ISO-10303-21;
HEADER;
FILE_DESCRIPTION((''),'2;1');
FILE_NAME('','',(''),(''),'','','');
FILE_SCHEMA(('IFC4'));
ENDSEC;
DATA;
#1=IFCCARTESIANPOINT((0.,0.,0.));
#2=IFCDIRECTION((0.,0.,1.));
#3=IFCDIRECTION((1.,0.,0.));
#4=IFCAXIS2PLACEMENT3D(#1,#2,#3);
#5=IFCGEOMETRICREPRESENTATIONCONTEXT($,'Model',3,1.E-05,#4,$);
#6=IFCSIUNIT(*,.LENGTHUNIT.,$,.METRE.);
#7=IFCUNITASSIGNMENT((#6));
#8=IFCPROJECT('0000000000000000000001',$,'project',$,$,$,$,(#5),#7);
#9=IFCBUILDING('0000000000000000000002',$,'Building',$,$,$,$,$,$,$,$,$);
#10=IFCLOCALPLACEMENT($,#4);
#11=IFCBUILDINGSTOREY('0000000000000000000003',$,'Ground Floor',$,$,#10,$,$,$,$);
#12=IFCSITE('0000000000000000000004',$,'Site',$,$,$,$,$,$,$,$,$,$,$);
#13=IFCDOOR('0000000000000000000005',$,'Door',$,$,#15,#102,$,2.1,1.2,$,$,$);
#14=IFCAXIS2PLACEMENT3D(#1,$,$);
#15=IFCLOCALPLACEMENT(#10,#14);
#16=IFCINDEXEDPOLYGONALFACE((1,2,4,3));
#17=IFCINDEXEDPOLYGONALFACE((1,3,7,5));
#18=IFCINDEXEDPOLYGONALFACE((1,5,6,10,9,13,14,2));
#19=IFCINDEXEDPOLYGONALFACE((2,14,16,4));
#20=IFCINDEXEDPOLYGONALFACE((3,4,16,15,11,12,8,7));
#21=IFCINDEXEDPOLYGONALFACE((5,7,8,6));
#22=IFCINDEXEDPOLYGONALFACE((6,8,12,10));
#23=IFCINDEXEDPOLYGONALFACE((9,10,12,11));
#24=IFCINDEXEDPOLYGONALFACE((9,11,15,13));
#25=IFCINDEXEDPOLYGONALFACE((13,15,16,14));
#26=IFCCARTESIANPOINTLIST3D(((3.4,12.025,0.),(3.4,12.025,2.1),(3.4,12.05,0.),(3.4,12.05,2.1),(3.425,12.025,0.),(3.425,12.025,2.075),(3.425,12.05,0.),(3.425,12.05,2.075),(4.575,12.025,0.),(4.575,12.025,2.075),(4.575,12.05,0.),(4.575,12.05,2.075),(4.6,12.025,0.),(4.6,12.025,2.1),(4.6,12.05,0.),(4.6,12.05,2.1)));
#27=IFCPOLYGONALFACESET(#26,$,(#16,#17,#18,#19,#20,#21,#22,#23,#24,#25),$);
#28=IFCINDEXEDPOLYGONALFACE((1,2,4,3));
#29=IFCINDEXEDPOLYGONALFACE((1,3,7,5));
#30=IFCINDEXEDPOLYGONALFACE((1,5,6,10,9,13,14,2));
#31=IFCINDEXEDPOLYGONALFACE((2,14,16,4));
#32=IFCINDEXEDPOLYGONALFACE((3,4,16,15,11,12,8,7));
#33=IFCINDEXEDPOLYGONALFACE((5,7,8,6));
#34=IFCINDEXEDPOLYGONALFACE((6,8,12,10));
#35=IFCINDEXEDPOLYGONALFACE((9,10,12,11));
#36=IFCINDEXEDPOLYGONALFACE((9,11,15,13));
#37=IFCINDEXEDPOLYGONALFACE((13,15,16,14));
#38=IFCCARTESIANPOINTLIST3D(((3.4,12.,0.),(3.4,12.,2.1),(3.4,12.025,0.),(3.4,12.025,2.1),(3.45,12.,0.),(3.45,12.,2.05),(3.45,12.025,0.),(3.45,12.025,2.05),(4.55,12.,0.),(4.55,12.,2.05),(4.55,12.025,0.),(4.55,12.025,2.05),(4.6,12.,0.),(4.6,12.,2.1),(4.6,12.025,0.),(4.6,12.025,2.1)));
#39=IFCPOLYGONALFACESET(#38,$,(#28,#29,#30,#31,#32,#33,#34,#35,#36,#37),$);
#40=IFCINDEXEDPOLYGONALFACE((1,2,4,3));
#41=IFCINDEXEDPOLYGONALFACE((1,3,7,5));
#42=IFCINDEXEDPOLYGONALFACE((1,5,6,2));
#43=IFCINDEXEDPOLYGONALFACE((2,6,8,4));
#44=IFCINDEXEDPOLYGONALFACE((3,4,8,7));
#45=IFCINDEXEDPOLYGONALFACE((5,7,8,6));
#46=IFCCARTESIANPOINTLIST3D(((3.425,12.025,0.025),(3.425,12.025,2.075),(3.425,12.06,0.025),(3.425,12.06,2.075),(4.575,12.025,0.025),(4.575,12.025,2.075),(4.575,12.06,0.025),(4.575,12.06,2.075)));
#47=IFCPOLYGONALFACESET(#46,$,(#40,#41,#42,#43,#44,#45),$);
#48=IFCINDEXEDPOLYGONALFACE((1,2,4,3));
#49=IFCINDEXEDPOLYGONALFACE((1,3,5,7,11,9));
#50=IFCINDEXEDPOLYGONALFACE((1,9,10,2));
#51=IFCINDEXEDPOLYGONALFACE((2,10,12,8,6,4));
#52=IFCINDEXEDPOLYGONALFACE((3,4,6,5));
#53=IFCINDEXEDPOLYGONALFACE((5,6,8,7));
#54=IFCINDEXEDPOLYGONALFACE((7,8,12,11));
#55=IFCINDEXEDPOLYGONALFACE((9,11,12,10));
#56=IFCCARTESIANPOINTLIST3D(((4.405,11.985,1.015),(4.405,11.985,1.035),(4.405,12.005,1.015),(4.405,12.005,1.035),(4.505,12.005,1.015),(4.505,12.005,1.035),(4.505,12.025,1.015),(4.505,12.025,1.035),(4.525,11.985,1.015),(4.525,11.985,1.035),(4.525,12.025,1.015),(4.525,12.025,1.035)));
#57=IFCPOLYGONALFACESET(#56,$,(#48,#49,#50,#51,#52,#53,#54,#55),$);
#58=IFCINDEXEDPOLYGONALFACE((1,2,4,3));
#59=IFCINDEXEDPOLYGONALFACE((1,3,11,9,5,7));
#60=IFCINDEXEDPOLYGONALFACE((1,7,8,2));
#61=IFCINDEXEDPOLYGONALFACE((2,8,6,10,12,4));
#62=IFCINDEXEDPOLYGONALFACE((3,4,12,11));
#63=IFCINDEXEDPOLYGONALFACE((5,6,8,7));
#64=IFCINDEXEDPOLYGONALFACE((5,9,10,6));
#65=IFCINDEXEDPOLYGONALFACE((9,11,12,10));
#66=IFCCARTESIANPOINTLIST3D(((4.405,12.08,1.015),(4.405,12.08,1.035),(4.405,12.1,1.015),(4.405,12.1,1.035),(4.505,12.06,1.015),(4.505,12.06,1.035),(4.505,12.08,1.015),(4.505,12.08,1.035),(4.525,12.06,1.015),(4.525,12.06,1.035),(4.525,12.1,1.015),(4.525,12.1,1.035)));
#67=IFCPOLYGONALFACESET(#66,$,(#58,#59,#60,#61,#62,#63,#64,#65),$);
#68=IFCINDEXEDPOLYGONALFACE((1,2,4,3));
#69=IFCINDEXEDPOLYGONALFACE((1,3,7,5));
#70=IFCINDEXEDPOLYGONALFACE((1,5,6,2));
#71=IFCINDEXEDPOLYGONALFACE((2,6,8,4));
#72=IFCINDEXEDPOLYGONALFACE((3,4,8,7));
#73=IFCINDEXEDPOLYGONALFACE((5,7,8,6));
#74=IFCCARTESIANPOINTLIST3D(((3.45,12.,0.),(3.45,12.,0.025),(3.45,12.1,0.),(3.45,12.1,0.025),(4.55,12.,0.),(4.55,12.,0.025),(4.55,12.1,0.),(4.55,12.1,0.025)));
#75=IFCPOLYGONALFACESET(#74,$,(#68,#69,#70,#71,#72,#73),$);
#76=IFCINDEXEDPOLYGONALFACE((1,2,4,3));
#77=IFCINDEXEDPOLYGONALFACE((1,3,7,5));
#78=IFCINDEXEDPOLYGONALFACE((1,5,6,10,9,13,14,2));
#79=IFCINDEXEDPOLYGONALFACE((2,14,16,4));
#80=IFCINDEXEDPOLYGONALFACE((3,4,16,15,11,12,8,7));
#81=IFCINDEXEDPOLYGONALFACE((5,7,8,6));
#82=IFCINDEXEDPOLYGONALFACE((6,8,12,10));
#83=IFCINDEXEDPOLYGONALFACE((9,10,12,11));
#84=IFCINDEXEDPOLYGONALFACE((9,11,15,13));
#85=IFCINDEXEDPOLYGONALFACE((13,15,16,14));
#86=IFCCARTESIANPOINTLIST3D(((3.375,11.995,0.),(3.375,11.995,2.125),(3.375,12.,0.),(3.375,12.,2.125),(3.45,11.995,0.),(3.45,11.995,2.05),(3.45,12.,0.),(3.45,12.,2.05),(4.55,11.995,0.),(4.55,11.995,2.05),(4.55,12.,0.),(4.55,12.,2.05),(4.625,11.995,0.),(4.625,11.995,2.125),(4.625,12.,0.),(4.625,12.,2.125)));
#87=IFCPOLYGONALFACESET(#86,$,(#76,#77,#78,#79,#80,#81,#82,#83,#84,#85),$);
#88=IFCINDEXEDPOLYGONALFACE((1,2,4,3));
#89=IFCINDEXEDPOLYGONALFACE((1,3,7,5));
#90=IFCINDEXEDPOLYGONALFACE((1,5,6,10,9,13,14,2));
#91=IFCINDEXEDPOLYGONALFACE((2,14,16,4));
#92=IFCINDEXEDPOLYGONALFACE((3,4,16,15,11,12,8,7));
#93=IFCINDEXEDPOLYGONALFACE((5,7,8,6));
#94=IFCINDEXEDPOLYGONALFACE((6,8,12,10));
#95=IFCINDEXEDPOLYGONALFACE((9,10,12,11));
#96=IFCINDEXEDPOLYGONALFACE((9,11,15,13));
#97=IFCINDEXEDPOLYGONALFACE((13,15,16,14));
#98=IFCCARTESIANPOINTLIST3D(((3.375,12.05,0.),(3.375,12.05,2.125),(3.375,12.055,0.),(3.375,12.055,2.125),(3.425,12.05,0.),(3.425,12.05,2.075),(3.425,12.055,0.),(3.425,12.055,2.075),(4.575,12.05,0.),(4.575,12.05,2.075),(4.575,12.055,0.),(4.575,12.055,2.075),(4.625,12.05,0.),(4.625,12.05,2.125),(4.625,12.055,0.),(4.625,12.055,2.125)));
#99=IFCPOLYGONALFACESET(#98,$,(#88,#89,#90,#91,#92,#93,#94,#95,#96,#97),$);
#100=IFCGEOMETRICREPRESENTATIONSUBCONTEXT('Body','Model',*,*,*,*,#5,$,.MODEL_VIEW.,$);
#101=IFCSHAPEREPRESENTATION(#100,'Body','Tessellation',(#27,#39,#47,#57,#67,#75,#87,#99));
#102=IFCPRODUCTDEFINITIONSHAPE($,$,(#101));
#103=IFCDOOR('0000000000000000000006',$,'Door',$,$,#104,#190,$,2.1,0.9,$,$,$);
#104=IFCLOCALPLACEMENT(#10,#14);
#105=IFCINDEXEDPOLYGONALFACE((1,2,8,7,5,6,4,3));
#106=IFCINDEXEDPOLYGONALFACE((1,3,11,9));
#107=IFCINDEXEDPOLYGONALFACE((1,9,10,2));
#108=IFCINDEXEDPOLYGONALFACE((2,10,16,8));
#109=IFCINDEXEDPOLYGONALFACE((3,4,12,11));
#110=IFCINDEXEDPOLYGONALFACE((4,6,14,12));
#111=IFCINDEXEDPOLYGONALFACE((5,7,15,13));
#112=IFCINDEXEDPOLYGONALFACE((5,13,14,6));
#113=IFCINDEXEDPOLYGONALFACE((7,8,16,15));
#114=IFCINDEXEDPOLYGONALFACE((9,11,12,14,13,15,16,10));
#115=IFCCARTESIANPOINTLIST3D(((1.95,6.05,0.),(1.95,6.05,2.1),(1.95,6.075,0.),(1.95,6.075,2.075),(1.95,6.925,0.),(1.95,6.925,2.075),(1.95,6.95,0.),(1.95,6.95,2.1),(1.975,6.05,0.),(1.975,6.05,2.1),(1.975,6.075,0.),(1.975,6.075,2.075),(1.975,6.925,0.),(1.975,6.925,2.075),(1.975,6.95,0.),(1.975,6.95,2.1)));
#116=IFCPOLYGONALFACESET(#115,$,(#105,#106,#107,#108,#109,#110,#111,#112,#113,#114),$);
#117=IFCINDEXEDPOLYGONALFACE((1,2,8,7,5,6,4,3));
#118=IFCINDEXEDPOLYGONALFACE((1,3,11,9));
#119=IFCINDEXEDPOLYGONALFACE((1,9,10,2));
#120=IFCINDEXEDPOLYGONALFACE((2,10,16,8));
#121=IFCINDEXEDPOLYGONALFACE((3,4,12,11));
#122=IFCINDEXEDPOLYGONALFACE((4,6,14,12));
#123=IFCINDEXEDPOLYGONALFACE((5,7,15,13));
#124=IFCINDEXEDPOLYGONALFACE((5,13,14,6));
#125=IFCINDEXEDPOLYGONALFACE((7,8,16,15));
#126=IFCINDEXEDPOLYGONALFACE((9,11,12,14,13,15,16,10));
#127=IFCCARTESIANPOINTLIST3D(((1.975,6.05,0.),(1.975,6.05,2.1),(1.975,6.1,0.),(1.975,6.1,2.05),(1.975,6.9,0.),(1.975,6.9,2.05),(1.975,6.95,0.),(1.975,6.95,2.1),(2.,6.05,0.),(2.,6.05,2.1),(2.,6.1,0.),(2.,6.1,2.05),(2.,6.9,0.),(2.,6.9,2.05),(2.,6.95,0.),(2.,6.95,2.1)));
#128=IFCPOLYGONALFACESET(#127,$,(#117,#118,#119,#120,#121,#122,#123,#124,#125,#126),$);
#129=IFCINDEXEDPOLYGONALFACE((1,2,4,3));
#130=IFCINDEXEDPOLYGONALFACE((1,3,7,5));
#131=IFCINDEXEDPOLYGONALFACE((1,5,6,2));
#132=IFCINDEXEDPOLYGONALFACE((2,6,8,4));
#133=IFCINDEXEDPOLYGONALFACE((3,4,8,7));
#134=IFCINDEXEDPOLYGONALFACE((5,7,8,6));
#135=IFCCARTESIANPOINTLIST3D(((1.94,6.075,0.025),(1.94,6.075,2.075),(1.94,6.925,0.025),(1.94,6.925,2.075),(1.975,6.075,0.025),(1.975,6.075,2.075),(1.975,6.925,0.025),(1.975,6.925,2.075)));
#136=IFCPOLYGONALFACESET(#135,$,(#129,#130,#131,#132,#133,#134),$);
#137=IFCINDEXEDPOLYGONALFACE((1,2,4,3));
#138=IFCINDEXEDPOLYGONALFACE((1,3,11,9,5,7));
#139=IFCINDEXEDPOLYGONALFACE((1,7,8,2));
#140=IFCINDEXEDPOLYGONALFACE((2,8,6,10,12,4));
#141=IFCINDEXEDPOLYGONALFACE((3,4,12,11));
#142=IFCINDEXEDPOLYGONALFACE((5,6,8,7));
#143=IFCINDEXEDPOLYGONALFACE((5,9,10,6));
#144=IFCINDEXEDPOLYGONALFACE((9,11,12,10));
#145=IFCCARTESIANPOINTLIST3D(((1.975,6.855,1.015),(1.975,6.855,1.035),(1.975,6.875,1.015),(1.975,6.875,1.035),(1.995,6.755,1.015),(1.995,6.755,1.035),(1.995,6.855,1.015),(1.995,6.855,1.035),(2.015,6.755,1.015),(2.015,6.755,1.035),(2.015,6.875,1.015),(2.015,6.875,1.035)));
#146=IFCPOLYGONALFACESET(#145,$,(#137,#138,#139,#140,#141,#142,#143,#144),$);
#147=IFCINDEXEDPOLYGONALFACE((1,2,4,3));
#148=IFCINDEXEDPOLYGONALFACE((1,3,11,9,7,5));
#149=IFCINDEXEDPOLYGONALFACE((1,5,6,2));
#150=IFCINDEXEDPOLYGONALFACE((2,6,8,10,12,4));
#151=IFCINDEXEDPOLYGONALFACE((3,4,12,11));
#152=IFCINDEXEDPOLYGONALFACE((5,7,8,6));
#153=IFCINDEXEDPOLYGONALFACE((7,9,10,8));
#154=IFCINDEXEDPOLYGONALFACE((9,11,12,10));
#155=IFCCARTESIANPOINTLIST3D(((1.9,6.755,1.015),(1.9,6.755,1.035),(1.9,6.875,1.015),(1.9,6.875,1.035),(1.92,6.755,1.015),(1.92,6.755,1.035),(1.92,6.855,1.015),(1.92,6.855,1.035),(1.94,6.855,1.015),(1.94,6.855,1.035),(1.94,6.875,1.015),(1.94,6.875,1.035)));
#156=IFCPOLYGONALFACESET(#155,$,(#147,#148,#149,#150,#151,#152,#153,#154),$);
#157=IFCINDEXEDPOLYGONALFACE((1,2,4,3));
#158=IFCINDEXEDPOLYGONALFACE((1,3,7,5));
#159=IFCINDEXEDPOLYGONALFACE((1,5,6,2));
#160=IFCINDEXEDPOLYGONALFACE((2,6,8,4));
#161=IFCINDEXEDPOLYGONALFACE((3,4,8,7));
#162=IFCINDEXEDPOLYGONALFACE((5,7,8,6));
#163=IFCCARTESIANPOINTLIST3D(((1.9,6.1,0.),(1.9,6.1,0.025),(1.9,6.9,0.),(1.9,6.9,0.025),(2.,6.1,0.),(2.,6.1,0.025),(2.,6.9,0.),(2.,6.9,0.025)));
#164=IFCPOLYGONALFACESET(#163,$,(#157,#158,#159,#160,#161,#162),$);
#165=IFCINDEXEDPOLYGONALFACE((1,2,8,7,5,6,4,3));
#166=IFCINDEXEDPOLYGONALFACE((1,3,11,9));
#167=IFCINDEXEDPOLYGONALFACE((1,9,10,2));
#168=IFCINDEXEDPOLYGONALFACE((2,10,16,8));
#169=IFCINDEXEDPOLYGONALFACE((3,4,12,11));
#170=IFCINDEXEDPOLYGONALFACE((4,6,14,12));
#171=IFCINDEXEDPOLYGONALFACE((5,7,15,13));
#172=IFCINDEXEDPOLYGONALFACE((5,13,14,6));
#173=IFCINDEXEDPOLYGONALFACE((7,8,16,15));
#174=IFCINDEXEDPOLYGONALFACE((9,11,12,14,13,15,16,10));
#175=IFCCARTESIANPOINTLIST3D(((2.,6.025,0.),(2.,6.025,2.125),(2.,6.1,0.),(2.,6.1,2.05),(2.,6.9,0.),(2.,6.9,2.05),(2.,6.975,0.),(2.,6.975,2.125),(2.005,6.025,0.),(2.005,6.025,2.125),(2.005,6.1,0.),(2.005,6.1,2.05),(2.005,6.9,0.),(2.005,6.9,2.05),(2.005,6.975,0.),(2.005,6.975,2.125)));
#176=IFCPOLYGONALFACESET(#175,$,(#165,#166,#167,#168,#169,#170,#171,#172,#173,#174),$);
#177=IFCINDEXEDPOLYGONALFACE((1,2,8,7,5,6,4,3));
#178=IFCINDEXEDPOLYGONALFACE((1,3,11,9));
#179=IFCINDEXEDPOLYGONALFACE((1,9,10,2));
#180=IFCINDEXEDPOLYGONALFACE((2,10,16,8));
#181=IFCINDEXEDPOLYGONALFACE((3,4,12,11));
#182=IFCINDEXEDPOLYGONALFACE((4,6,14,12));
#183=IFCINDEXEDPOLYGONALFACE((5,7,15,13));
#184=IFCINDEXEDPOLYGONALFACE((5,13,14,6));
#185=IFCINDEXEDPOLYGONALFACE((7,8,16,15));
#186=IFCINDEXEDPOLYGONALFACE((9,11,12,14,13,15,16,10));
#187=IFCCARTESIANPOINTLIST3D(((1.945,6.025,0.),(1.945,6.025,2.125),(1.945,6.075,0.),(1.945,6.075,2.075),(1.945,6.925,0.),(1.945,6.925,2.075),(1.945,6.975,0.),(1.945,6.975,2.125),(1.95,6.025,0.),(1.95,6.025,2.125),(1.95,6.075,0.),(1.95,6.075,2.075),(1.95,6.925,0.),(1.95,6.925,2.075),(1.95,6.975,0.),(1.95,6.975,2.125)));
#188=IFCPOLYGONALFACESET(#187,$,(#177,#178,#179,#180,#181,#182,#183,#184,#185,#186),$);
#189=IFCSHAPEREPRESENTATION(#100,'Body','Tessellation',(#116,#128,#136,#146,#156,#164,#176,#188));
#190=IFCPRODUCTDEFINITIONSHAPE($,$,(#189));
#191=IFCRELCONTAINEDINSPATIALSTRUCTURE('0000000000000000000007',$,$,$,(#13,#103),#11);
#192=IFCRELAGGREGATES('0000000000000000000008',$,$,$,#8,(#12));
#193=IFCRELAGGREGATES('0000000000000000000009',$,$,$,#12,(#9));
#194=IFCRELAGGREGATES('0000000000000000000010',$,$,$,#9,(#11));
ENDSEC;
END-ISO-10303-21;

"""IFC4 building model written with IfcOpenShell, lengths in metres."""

from ifc_helpers import new_model, si_unit, frame, origin_with_axes, place, context, subcontext, project, spatial, line, indexed_curve, outline, extrude, element, save


model = new_model("IFC4")

# Units and contexts
model_context = context("Model", 3, precision=1e-05, world=origin_with_axes())
body_context = subcontext(model_context, "Body", "Model", "MODEL_VIEW")
ifc_project = project(units=[si_unit("LENGTHUNIT", "METRE")], contexts=[model_context])

# Site, building, storey
site = spatial("IfcSite", under=ifc_project, Name="Site")
building = spatial("IfcBuilding", under=site, Name="Building")
storey_placement = place(None, origin_with_axes())
storey = spatial("IfcBuildingStorey", under=building, at=storey_placement, Name="Ground Floor")

# Doors
door_1_placement = place(storey_placement, frame((3.4, 12.0, 0.0), z_axis=(0.0, 0.0, 1.0), x_axis=(1.0, 0.0, 0.0)))
element("IfcDoor", 1, at=door_1_placement, inside=storey, Name="Door", OverallHeight=2.1, OverallWidth=1.2, context=body_context, shape_type="SweptSolid", body=[
    extrude(outline(indexed_curve([(0.0, 0.0), (0.0, 2.1), (1.2, 2.1), (1.2, 0.0), (1.175, 0.0), (1.175, 2.075), (0.025, 2.075), (0.025, 0.0)], segments=[line(1, 2, 3, 4, 5, 6, 7, 8, 1)])), frame((0.0, 0.025, 0.0), z_axis=(0.0, -1.0, 0.0), x_axis=(1.0, 0.0, 0.0)), (0.0, 0.0, -1.0), 0.025),
    extrude(outline(indexed_curve([(0.0, 0.0), (0.0, 2.1), (1.2, 2.1), (1.2, 0.0), (1.15, 0.0), (1.15, 2.05), (0.05, 2.05), (0.05, 0.0)], segments=[line(1, 2, 3, 4, 5, 6, 7, 8, 1)])), frame((0.0, 0.0, 0.0), z_axis=(0.0, -1.0, 0.0), x_axis=(1.0, 0.0, 0.0)), (0.0, 0.0, -1.0), 0.025),
    extrude(outline(indexed_curve([(0.0, 0.0), (1.15, 0.0), (1.15, 0.035), (0.0, 0.035)], segments=[line(1, 2, 3, 4, 1)])), frame((0.025, 0.025, 0.025), z_axis=(0.0, 0.0, 1.0), x_axis=(1.0, 0.0, 0.0)), (0.0, 0.0, 1.0), 2.05),
    extrude(outline(indexed_curve([(0.0, 0.0), (0.0, -0.04), (-0.12, -0.04), (-0.12, -0.02), (-0.02, -0.02), (-0.02, 0.0)], segments=[line(1, 2, 3, 4, 5, 6, 1)])), frame((1.125, 0.025, 1.015), z_axis=(0.0, 0.0, 1.0), x_axis=(1.0, 0.0, 0.0)), (0.0, 0.0, 1.0), 0.02),
    extrude(outline(indexed_curve([(0.0, 0.0), (0.0, 0.04), (-0.12, 0.04), (-0.12, 0.02), (-0.02, 0.02), (-0.02, 0.0)], segments=[line(1, 2, 3, 4, 5, 6, 1)])), frame((1.125, 0.06, 1.015), z_axis=(0.0, 0.0, 1.0), x_axis=(1.0, 0.0, 0.0)), (0.0, 0.0, 1.0), 0.02),
    extrude(outline(indexed_curve([(0.0, 0.0), (1.1, 0.0), (1.1, 0.1), (0.0, 0.1)], segments=[line(1, 2, 3, 4, 1)])), frame((0.05, 0.0, 0.0), z_axis=(0.0, 0.0, 1.0), x_axis=(1.0, 0.0, 0.0)), (0.0, 0.0, 1.0), 0.025),
    extrude(outline(indexed_curve([(0.0, 0.0), (0.0, 2.125), (1.25, 2.125), (1.25, 0.0), (1.175, 0.0), (1.175, 2.05), (0.075, 2.05), (0.075, 0.0)], segments=[line(1, 2, 3, 4, 5, 6, 7, 8, 1)])), frame((-0.025, -0.005, 0.0), z_axis=(0.0, -1.0, 0.0), x_axis=(1.0, 0.0, 0.0)), (0.0, 0.0, -1.0), 0.005),
    extrude(outline(indexed_curve([(0.0, 0.0), (0.0, 2.125), (1.25, 2.125), (1.25, 0.0), (1.2, 0.0), (1.2, 2.075), (0.05, 2.075), (0.05, 0.0)], segments=[line(1, 2, 3, 4, 5, 6, 7, 8, 1)])), frame((-0.025, 0.05, 0.0), z_axis=(0.0, -1.0, 0.0), x_axis=(1.0, 0.0, 0.0)), (0.0, 0.0, -1.0), 0.005),
])
door_2_placement = place(storey_placement, frame((2.0, 6.05, 0.0), z_axis=(0.0, 0.0, 1.0), x_axis=(0.0, 1.0, 0.0)))
element("IfcDoor", 2, at=door_2_placement, inside=storey, Name="Door", OverallHeight=2.1, OverallWidth=0.9, context=body_context, shape_type="SweptSolid", body=[
    extrude(outline(indexed_curve([(0.0, 0.0), (0.0, 2.1), (0.9, 2.1), (0.9, 0.0), (0.875, 0.0), (0.875, 2.075), (0.025, 2.075), (0.025, 0.0)], segments=[line(1, 2, 3, 4, 5, 6, 7, 8, 1)])), frame((0.0, 0.025, 0.0), z_axis=(0.0, -1.0, 0.0), x_axis=(1.0, 0.0, 0.0)), (0.0, 0.0, -1.0), 0.025),
    extrude(outline(indexed_curve([(0.0, 0.0), (0.0, 2.1), (0.9, 2.1), (0.9, 0.0), (0.85, 0.0), (0.85, 2.05), (0.05, 2.05), (0.05, 0.0)], segments=[line(1, 2, 3, 4, 5, 6, 7, 8, 1)])), frame((0.0, 0.0, 0.0), z_axis=(0.0, -1.0, 0.0), x_axis=(1.0, 0.0, 0.0)), (0.0, 0.0, -1.0), 0.025),
    extrude(outline(indexed_curve([(0.0, 0.0), (0.85, 0.0), (0.85, 0.035), (0.0, 0.035)], segments=[line(1, 2, 3, 4, 1)])), frame((0.025, 0.025, 0.025), z_axis=(0.0, 0.0, 1.0), x_axis=(1.0, 0.0, 0.0)), (0.0, 0.0, 1.0), 2.05),
    extrude(outline(indexed_curve([(0.0, 0.0), (0.0, -0.04), (-0.12, -0.04), (-0.12, -0.02), (-0.02, -0.02), (-0.02, 0.0)], segments=[line(1, 2, 3, 4, 5, 6, 1)])), frame((0.825, 0.025, 1.015), z_axis=(0.0, 0.0, 1.0), x_axis=(1.0, 0.0, 0.0)), (0.0, 0.0, 1.0), 0.02),
    extrude(outline(indexed_curve([(0.0, 0.0), (0.0, 0.04), (-0.12, 0.04), (-0.12, 0.02), (-0.02, 0.02), (-0.02, 0.0)], segments=[line(1, 2, 3, 4, 5, 6, 1)])), frame((0.825, 0.06, 1.015), z_axis=(0.0, 0.0, 1.0), x_axis=(1.0, 0.0, 0.0)), (0.0, 0.0, 1.0), 0.02),
    extrude(outline(indexed_curve([(0.0, 0.0), (0.8, 0.0), (0.8, 0.1), (0.0, 0.1)], segments=[line(1, 2, 3, 4, 1)])), frame((0.05, 0.0, 0.0), z_axis=(0.0, 0.0, 1.0), x_axis=(1.0, 0.0, 0.0)), (0.0, 0.0, 1.0), 0.025),
    extrude(outline(indexed_curve([(0.0, 0.0), (0.0, 2.125), (0.95, 2.125), (0.95, 0.0), (0.875, 0.0), (0.875, 2.05), (0.075, 2.05), (0.075, 0.0)], segments=[line(1, 2, 3, 4, 5, 6, 7, 8, 1)])), frame((-0.025, -0.005, 0.0), z_axis=(0.0, -1.0, 0.0), x_axis=(1.0, 0.0, 0.0)), (0.0, 0.0, -1.0), 0.005),
    extrude(outline(indexed_curve([(0.0, 0.0), (0.0, 2.125), (0.95, 2.125), (0.95, 0.0), (0.9, 0.0), (0.9, 2.075), (0.05, 2.075), (0.05, 0.0)], segments=[line(1, 2, 3, 4, 5, 6, 7, 8, 1)])), frame((-0.025, 0.05, 0.0), z_axis=(0.0, -1.0, 0.0), x_axis=(1.0, 0.0, 0.0)), (0.0, 0.0, -1.0), 0.005),
])

save(model, "model.ifc")
